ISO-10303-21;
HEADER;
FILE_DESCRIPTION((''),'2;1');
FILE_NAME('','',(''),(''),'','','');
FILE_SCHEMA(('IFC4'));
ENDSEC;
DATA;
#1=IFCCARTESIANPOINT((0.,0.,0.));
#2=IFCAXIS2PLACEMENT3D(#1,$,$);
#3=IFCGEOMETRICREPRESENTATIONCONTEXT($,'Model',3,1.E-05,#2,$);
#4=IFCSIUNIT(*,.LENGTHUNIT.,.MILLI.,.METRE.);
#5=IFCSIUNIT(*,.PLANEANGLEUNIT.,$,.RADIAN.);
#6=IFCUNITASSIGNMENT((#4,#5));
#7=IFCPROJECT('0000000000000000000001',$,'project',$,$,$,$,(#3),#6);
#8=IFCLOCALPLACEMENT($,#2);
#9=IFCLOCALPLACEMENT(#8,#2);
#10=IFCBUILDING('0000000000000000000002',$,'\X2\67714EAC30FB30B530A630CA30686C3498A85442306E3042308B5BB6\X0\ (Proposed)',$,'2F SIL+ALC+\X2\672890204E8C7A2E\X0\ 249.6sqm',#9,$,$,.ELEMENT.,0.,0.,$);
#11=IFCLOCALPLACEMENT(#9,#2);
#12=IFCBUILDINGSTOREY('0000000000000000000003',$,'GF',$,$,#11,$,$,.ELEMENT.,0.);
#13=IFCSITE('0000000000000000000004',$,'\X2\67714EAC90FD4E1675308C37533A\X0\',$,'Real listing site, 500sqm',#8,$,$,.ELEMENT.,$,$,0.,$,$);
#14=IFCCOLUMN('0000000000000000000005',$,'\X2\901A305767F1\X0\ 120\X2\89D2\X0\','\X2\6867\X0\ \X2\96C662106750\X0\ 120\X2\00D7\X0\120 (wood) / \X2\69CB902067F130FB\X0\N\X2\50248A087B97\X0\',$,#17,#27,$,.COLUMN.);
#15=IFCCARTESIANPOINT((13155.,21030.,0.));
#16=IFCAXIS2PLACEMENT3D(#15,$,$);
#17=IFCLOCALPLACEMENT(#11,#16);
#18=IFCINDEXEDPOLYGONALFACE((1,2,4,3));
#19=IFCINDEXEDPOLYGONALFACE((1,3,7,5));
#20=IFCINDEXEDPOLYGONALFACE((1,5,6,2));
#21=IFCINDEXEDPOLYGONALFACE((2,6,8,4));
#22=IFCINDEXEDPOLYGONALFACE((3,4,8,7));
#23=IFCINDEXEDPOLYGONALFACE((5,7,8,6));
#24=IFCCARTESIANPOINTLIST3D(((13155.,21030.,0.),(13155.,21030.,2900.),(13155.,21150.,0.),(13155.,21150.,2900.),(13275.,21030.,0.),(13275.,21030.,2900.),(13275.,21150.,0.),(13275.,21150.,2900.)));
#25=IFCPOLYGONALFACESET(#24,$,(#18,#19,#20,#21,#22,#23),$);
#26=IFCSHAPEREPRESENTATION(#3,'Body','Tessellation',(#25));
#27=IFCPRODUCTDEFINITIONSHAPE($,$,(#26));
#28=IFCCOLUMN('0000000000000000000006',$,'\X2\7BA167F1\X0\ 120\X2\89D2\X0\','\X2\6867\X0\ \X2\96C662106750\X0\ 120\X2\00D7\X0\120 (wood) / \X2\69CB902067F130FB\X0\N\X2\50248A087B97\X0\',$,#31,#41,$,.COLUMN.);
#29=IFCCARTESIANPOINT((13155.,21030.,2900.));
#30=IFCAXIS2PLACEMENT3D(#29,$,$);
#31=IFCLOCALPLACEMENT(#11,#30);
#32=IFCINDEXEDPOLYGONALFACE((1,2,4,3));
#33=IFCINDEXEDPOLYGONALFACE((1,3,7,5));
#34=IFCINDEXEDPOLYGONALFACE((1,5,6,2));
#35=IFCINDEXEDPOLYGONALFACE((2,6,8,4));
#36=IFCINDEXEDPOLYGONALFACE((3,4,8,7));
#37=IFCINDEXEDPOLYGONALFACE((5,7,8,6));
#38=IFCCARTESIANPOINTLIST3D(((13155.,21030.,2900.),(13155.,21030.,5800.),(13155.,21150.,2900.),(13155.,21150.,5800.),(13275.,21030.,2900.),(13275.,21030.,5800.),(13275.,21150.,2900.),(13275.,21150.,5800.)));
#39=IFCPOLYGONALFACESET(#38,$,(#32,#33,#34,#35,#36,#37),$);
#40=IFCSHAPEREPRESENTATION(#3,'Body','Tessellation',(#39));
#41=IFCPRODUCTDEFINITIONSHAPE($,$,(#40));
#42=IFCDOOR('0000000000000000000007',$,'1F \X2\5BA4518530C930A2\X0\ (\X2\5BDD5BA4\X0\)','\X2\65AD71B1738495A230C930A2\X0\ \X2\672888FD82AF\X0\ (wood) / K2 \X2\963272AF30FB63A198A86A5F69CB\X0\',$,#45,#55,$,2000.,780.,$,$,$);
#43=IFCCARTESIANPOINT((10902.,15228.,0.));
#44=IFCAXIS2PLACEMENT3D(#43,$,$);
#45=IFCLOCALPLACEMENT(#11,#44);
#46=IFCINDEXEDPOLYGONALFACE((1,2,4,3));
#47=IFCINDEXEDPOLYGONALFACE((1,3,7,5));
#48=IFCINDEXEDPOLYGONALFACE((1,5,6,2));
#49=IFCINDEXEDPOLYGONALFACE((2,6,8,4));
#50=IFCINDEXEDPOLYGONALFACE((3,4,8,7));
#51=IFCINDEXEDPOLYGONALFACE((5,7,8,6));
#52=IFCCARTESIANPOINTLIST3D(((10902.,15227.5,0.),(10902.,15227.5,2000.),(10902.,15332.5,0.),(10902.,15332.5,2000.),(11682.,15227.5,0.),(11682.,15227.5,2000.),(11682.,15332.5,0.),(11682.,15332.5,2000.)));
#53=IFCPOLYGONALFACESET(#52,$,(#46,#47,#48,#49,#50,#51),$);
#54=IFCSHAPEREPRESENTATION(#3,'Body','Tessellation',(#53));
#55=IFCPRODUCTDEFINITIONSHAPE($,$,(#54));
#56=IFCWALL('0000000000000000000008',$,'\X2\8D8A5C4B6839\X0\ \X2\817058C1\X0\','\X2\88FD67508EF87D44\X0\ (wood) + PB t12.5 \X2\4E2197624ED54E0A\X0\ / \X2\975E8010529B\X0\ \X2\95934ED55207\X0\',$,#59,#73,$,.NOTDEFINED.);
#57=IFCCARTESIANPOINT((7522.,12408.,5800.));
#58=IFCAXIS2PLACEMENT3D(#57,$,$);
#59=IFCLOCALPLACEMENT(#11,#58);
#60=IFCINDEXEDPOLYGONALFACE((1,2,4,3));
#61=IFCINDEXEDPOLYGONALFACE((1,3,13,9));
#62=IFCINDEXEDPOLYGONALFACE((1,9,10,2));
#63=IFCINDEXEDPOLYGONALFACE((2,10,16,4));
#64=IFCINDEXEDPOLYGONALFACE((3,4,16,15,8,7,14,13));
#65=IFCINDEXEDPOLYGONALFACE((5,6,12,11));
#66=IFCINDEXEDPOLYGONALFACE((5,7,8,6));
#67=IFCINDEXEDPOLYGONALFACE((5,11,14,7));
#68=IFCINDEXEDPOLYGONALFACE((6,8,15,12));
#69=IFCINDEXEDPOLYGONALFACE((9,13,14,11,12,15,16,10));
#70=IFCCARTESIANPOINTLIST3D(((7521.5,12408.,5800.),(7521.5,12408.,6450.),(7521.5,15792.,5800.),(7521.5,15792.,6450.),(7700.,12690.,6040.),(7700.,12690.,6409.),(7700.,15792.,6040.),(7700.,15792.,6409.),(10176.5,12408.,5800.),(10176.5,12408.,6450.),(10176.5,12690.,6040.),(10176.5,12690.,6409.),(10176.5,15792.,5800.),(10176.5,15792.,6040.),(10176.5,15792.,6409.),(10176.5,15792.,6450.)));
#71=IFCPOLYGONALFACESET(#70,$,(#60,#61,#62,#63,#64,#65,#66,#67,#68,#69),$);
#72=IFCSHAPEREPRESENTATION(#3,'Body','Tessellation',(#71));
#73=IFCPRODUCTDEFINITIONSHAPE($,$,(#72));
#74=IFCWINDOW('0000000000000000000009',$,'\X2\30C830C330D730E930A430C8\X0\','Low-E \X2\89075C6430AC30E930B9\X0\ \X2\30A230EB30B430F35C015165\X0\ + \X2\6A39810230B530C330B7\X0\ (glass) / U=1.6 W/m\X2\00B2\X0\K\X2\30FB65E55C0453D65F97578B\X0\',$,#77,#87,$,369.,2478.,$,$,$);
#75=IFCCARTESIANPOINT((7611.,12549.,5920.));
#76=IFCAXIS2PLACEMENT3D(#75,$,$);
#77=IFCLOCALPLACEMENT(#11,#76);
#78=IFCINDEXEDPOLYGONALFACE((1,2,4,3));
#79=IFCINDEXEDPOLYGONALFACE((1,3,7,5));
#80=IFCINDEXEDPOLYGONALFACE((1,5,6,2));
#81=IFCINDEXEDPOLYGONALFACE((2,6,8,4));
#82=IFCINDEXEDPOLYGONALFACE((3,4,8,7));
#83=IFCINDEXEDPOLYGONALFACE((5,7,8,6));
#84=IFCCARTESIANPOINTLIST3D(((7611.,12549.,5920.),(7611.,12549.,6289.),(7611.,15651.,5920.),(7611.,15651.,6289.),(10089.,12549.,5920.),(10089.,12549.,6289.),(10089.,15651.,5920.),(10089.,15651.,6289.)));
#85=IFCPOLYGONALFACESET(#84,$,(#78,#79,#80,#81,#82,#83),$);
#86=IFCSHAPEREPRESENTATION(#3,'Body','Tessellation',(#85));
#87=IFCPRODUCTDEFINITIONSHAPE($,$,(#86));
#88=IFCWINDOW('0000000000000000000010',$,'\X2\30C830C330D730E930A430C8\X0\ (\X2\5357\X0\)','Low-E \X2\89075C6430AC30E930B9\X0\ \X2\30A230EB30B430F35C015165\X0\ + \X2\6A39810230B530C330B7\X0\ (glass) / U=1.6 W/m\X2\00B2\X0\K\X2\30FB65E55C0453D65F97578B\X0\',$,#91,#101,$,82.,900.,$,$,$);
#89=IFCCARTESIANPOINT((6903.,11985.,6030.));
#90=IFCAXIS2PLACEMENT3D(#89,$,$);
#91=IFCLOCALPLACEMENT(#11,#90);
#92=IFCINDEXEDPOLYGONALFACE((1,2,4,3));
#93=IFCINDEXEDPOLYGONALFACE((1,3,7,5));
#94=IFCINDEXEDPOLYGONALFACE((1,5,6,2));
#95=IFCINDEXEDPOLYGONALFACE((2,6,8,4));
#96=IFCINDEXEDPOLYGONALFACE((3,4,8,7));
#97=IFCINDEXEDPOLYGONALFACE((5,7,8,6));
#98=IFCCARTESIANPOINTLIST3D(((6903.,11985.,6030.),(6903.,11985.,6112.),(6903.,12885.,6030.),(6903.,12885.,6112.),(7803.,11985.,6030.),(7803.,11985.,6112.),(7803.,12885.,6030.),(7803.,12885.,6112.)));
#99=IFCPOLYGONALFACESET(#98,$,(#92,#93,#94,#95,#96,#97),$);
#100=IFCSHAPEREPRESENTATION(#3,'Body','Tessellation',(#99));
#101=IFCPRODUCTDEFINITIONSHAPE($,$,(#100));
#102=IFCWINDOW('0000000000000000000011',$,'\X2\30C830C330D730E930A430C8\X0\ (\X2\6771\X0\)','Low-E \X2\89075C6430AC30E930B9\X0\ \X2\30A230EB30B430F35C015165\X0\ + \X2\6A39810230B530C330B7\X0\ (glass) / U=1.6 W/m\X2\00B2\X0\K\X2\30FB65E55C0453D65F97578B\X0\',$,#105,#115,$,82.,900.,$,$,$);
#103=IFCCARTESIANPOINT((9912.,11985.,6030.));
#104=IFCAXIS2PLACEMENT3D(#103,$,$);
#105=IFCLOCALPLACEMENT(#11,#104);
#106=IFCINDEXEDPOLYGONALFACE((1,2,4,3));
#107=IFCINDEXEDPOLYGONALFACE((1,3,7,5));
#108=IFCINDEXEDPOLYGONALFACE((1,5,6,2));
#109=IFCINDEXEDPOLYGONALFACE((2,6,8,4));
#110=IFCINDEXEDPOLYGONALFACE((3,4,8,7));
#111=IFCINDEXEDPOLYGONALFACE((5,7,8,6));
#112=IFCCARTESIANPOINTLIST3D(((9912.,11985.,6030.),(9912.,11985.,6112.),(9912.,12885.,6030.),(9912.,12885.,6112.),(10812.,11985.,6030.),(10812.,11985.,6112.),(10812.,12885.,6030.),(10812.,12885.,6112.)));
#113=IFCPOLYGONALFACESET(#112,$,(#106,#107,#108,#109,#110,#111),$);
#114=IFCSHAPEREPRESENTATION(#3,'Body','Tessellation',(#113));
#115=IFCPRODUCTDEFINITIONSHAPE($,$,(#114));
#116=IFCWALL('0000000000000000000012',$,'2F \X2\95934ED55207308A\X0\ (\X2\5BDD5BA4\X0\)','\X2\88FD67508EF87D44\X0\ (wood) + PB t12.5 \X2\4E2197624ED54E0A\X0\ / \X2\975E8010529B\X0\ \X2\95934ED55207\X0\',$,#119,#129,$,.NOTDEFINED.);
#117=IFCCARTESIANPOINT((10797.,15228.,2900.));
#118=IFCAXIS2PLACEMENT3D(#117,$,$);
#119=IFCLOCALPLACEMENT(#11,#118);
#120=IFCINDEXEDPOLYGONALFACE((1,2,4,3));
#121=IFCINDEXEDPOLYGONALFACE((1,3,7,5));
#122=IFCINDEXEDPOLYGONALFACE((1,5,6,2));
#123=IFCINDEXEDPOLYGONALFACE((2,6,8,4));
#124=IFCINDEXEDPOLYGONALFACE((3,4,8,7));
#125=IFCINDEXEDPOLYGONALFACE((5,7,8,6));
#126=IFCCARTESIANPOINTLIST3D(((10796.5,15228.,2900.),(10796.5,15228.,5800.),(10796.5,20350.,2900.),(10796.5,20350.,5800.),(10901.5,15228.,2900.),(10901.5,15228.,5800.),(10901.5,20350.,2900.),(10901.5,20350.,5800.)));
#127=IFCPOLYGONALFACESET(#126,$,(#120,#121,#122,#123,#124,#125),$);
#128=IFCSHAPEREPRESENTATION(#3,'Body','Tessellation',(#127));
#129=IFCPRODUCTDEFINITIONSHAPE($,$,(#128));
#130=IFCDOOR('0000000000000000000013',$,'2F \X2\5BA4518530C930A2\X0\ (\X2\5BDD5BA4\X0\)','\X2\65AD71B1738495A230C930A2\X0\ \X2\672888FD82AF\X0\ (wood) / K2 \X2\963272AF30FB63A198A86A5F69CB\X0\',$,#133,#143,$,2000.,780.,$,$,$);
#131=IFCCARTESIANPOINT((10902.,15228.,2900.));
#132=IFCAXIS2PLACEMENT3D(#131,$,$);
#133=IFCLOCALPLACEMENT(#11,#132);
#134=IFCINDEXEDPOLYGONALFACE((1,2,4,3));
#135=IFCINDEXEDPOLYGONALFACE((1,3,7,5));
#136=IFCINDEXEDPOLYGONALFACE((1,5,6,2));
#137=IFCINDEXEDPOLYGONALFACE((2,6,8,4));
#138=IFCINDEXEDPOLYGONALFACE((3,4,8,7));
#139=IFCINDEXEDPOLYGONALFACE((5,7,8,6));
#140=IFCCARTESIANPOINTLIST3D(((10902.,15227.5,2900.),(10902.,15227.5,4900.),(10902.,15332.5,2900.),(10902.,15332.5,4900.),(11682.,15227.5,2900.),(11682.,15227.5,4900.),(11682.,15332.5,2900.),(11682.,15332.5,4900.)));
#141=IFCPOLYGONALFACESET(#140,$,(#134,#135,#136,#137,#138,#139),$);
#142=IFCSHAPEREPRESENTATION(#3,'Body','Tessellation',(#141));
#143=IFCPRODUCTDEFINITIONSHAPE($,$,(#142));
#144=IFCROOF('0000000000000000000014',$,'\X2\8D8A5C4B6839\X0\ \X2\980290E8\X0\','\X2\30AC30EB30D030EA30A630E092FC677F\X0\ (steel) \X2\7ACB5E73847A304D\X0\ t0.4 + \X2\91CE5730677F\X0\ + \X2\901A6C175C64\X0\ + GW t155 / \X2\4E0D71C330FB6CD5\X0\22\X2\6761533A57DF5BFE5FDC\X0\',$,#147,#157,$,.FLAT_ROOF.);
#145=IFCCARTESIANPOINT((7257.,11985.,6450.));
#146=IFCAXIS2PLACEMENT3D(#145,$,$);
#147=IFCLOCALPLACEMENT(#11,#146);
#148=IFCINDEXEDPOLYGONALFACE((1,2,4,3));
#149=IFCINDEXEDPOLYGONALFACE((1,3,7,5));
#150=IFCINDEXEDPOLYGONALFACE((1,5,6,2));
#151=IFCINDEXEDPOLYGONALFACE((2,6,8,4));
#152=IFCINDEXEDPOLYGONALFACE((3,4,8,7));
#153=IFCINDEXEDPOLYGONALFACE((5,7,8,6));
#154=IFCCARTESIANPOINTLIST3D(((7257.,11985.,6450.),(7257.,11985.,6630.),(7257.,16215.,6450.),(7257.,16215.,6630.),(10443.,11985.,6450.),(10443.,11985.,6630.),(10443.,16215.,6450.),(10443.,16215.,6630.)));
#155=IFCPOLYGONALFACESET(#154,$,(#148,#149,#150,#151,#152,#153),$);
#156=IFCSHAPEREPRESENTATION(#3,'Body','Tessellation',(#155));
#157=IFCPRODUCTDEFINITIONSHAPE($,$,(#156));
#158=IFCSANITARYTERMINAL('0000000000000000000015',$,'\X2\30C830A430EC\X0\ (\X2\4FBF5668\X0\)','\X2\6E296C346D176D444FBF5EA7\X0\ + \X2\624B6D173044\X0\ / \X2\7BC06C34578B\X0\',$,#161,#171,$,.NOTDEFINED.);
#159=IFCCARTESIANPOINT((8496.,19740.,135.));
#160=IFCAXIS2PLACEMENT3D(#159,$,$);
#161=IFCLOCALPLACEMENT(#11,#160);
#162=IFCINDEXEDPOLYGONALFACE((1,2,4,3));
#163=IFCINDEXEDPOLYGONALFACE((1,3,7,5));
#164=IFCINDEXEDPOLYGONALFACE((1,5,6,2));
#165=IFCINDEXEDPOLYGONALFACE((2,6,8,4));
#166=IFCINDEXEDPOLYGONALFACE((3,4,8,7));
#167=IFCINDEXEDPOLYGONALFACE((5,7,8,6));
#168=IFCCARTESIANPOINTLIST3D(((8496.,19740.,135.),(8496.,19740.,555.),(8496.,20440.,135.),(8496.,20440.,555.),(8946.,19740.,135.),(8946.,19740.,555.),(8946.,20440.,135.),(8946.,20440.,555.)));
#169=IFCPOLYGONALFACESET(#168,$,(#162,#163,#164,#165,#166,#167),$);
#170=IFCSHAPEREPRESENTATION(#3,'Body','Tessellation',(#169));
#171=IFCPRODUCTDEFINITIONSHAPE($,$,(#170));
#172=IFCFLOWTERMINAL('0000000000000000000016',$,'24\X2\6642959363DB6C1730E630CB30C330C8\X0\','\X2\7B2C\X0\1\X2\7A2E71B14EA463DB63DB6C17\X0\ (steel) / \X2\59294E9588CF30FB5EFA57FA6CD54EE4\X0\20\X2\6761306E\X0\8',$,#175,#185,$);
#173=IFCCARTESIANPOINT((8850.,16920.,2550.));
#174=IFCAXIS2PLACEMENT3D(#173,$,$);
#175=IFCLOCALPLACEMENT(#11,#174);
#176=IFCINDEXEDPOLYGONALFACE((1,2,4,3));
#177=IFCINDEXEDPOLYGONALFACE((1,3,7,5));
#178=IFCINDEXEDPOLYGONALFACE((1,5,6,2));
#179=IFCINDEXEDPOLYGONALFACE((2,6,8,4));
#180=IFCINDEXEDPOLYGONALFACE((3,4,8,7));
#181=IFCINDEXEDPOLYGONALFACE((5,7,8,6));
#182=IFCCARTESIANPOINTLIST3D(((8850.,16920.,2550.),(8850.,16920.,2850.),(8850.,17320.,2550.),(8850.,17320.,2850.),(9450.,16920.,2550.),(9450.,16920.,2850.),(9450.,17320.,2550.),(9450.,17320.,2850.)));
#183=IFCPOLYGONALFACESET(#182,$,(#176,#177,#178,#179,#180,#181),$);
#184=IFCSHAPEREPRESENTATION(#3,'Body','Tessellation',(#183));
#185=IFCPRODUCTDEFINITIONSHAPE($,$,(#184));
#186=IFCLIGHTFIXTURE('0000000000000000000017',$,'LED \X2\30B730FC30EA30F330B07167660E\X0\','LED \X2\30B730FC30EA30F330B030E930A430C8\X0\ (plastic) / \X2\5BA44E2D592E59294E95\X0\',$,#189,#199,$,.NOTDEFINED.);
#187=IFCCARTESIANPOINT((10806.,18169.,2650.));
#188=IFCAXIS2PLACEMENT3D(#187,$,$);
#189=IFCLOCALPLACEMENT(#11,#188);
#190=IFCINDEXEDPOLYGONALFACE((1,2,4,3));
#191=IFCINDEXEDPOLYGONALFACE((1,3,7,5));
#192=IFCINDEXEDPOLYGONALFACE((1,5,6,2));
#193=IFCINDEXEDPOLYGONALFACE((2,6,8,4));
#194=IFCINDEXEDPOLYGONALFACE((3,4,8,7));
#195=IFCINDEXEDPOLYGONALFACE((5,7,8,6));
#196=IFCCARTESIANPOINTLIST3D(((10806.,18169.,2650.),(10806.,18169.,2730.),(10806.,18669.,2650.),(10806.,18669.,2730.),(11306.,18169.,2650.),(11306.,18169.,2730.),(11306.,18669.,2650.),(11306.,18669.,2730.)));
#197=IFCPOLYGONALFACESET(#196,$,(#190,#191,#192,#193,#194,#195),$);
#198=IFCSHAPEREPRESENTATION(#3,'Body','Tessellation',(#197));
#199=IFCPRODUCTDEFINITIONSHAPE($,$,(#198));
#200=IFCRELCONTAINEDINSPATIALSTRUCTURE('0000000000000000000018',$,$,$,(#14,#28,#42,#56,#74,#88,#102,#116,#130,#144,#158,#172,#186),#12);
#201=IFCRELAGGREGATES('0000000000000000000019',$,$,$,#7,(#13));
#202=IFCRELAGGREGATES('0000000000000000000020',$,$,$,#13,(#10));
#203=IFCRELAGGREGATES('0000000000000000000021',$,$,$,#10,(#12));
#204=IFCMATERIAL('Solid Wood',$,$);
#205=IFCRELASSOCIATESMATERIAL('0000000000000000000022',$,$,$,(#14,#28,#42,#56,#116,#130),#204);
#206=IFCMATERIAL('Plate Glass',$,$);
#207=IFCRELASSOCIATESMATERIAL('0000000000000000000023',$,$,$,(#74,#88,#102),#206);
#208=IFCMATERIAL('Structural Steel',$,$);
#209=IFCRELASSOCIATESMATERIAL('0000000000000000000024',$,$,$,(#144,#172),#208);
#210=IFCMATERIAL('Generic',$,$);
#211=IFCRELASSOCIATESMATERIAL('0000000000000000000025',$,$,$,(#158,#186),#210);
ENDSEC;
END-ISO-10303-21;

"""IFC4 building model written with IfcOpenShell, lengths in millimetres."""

from ifc_helpers import new_model, si_unit, frame, frame_2d, origin, place, context, project, spatial, rectangle, extrude, material, element, fill, save


model = new_model("IFC4")

# Units and contexts
model_context = context("Model", 3, precision=1e-05, world=origin())
ifc_project = project(units=[si_unit("LENGTHUNIT", "METRE", prefix="MILLI"), si_unit("PLANEANGLEUNIT", "RADIAN")], contexts=[model_context])

# Site, building, storey
site_placement = place(None, origin())
site = spatial("IfcSite", under=ifc_project, at=site_placement, Name="東京都世田谷区", ObjectType="Real listing site, 500sqm", CompositionType="ELEMENT", RefElevation=0.0)
building_placement = place(site_placement, origin())
building = spatial("IfcBuilding", under=site, at=building_placement, Name="東京・サウナと水風呂のある家 (Proposed)", ObjectType="2F SIL+ALC+木造二種 249.6sqm", CompositionType="ELEMENT", ElevationOfRefHeight=0.0, ElevationOfTerrain=0.0)
storey_placement = place(building_placement, origin())
storey = spatial("IfcBuildingStorey", under=building, at=storey_placement, Name="GF", CompositionType="ELEMENT", Elevation=0.0)

# Columns
ifc_material_1 = material(Name="Solid Wood")
column_1_placement = place(storey_placement, frame((13155.0, 21030.0, 0.0)))
element("IfcColumn", 1, at=column_1_placement, inside=storey, material=ifc_material_1, Name="通し柱 120角", Description="桧 集成材 120×120 (wood) / 構造柱・N値計算", PredefinedType="COLUMN", context=model_context, shape_type="SweptSolid", body=[
    extrude(rectangle(XDim=120.0, YDim=120.0, at=frame_2d((60.0, 60.0))), frame((13155.0, 21030.0, 0.0)), (0.0, 0.0, 1.0), 2900.0),
])
column_2_placement = place(storey_placement, frame((13155.0, 21030.0, 2900.0)))
element("IfcColumn", 2, at=column_2_placement, inside=storey, material=ifc_material_1, Name="管柱 120角", Description="桧 集成材 120×120 (wood) / 構造柱・N値計算", PredefinedType="COLUMN", context=model_context, shape_type="SweptSolid", body=[
    extrude(rectangle(XDim=120.0, YDim=120.0, at=frame_2d((60.0, 60.0))), frame((13155.0, 21030.0, 2900.0)), (0.0, 0.0, 1.0), 2900.0),
])

# Door
door_1_placement = place(storey_placement, frame((10902.0, 15228.0, 0.0)))
element("IfcDoor", 3, at=door_1_placement, inside=storey, material=ifc_material_1, Name="1F 室内ドア (寝室)", Description="断熱玄関ドア 木製芯 (wood) / K2 防犯・採風機構", OverallHeight=2000.0, OverallWidth=780.0, context=model_context, shape_type="SweptSolid", body=[
    extrude(rectangle(XDim=780.0, YDim=105.0, at=frame_2d((390.0, 52.0))), frame((10902.0, 15228.0, 0.0)), (0.0, 0.0, 1.0), 2000.0),
])

# Wall, openings, windows
wall_1_placement = place(storey_placement, frame((7522.0, 12408.0, 5800.0)))
wall_1 = element("IfcWall", 4, at=wall_1_placement, inside=storey, material=ifc_material_1, Name="越屋根 腰壁", Description="製材軸組 (wood) + PB t12.5 両面仕上 / 非耐力 間仕切", PredefinedType="NOTDEFINED", context=model_context, shape_type="SweptSolid", body=[
    extrude(rectangle(XDim=2655.0, YDim=3384.0, at=frame_2d((1327.0, 1692.0))), frame((7522.0, 12408.0, 5800.0)), (0.0, 0.0, 1.0), 650.0),
])
opening_1_placement = place(storey_placement, frame((7611.0, 12549.0, 5920.0)))
opening_1 = element("IfcOpeningElement", 5, at=opening_1_placement, cuts=wall_1, PredefinedType="NOTDEFINED", context=model_context, shape_type="SweptSolid", body=[
    extrude(rectangle(XDim=2478.0, YDim=3102.0, at=frame_2d((1239.0, 1551.0))), frame((7611.0, 12549.0, 5920.0)), (0.0, 0.0, 1.0), 369.0),
])
opening_2_placement = place(storey_placement, frame((6903.0, 11985.0, 6030.0)))
opening_2 = element("IfcOpeningElement", 6, at=opening_2_placement, cuts=wall_1, PredefinedType="NOTDEFINED", context=model_context, shape_type="SweptSolid", body=[
    extrude(rectangle(XDim=900.0, YDim=900.0, at=frame_2d((450.0, 450.0))), frame((6903.0, 11985.0, 6030.0)), (0.0, 0.0, 1.0), 82.0),
])
opening_3_placement = place(storey_placement, frame((9912.0, 11985.0, 6030.0)))
opening_3 = element("IfcOpeningElement", 7, at=opening_3_placement, cuts=wall_1, PredefinedType="NOTDEFINED", context=model_context, shape_type="SweptSolid", body=[
    extrude(rectangle(XDim=900.0, YDim=900.0, at=frame_2d((450.0, 450.0))), frame((9912.0, 11985.0, 6030.0)), (0.0, 0.0, 1.0), 82.0),
])
ifc_material_2 = material(Name="Plate Glass")
window_1_placement = place(storey_placement, frame((7611.0, 12549.0, 5920.0)))
window_1 = element("IfcWindow", 8, at=window_1_placement, inside=storey, material=ifc_material_2, Name="トップライト", Description="Low-E 複層ガラス アルゴン封入 + 樹脂サッシ (glass) / U=1.6 W/m²K・日射取得型", OverallHeight=369.0, OverallWidth=2478.0, context=model_context, shape_type="SweptSolid", body=[
    extrude(rectangle(XDim=2478.0, YDim=3102.0, at=frame_2d((1239.0, 1551.0))), frame((7611.0, 12549.0, 5920.0)), (0.0, 0.0, 1.0), 369.0),
])
fill(opening_1, window_1)
window_2_placement = place(storey_placement, frame((6903.0, 11985.0, 6030.0)))
window_2 = element("IfcWindow", 9, at=window_2_placement, inside=storey, material=ifc_material_2, Name="トップライト (南)", Description="Low-E 複層ガラス アルゴン封入 + 樹脂サッシ (glass) / U=1.6 W/m²K・日射取得型", OverallHeight=82.0, OverallWidth=900.0, context=model_context, shape_type="SweptSolid", body=[
    extrude(rectangle(XDim=900.0, YDim=900.0, at=frame_2d((450.0, 450.0))), frame((6903.0, 11985.0, 6030.0)), (0.0, 0.0, 1.0), 82.0),
])
fill(opening_2, window_2)
window_3_placement = place(storey_placement, frame((9912.0, 11985.0, 6030.0)))
window_3 = element("IfcWindow", 10, at=window_3_placement, inside=storey, material=ifc_material_2, Name="トップライト (東)", Description="Low-E 複層ガラス アルゴン封入 + 樹脂サッシ (glass) / U=1.6 W/m²K・日射取得型", OverallHeight=82.0, OverallWidth=900.0, context=model_context, shape_type="SweptSolid", body=[
    extrude(rectangle(XDim=900.0, YDim=900.0, at=frame_2d((450.0, 450.0))), frame((9912.0, 11985.0, 6030.0)), (0.0, 0.0, 1.0), 82.0),
])
fill(opening_3, window_3)

# Wall
wall_2_placement = place(storey_placement, frame((10797.0, 15228.0, 2900.0)))
element("IfcWall", 11, at=wall_2_placement, inside=storey, material=ifc_material_1, Name="2F 間仕切り (寝室)", Description="製材軸組 (wood) + PB t12.5 両面仕上 / 非耐力 間仕切", PredefinedType="NOTDEFINED", context=model_context, shape_type="SweptSolid", body=[
    extrude(rectangle(XDim=105.0, YDim=5122.0, at=frame_2d((52.0, 2561.0))), frame((10797.0, 15228.0, 2900.0)), (0.0, 0.0, 1.0), 2900.0),
])

# Door
door_2_placement = place(storey_placement, frame((10902.0, 15228.0, 2900.0)))
element("IfcDoor", 12, at=door_2_placement, inside=storey, material=ifc_material_1, Name="2F 室内ドア (寝室)", Description="断熱玄関ドア 木製芯 (wood) / K2 防犯・採風機構", OverallHeight=2000.0, OverallWidth=780.0, context=model_context, shape_type="SweptSolid", body=[
    extrude(rectangle(XDim=780.0, YDim=105.0, at=frame_2d((390.0, 52.0))), frame((10902.0, 15228.0, 2900.0)), (0.0, 0.0, 1.0), 2000.0),
])

# Roof
ifc_material_3 = material(Name="Structural Steel")
roof_placement = place(storey_placement, frame((7257.0, 11985.0, 6450.0)))
element("IfcRoof", 13, at=roof_placement, inside=storey, material=ifc_material_3, Name="越屋根 頂部", Description="ガルバリウム鋼板 (steel) 立平葺き t0.4 + 野地板 + 通気層 + GW t155 / 不燃・法22条区域対応", PredefinedType="FLAT_ROOF", context=model_context, shape_type="SweptSolid", body=[
    extrude(rectangle(XDim=3186.0, YDim=4230.0, at=frame_2d((1593.0, 2115.0))), frame((7257.0, 11985.0, 6450.0)), (0.0, 0.0, 1.0), 180.0),
])

# Sanitary terminal
ifc_material_4 = material(Name="Generic")
sanitary_terminal_placement = place(storey_placement, frame((8496.0, 19740.0, 135.0)))
element("IfcSanitaryTerminal", 14, at=sanitary_terminal_placement, inside=storey, material=ifc_material_4, Name="トイレ (便器)", Description="温水洗浄便座 + 手洗い / 節水型", PredefinedType="NOTDEFINED", context=model_context, shape_type="SweptSolid", body=[
    extrude(rectangle(XDim=450.0, YDim=700.0, at=frame_2d((225.0, 350.0))), frame((8496.0, 19740.0, 135.0)), (0.0, 0.0, 1.0), 420.0),
])

# Flow terminal
flow_terminal_placement = place(storey_placement, frame((8850.0, 16920.0, 2550.0)))
element("IfcFlowTerminal", 15, at=flow_terminal_placement, inside=storey, material=ifc_material_3, Name="24時間換気ユニット", Description="第1種熱交換換気 (steel) / 天井裏・建基法令20条の8", context=model_context, shape_type="SweptSolid", body=[
    extrude(rectangle(XDim=600.0, YDim=400.0, at=frame_2d((300.0, 200.0))), frame((8850.0, 16920.0, 2550.0)), (0.0, 0.0, 1.0), 300.0),
])

# Light fixture
light_fixture_1_placement = place(storey_placement, frame((10806.0, 18169.0, 2650.0)))
element("IfcLightFixture", 16, at=light_fixture_1_placement, inside=storey, material=ifc_material_4, Name="LED シーリング照明", Description="LED シーリングライト (plastic) / 室中央天井", PredefinedType="NOTDEFINED", context=model_context, shape_type="SweptSolid", body=[
    extrude(rectangle(XDim=500.0, YDim=500.0, at=frame_2d((250.0, 250.0))), frame((10806.0, 18169.0, 2650.0)), (0.0, 0.0, 1.0), 80.0),
])

save(model, "model.ifc")
